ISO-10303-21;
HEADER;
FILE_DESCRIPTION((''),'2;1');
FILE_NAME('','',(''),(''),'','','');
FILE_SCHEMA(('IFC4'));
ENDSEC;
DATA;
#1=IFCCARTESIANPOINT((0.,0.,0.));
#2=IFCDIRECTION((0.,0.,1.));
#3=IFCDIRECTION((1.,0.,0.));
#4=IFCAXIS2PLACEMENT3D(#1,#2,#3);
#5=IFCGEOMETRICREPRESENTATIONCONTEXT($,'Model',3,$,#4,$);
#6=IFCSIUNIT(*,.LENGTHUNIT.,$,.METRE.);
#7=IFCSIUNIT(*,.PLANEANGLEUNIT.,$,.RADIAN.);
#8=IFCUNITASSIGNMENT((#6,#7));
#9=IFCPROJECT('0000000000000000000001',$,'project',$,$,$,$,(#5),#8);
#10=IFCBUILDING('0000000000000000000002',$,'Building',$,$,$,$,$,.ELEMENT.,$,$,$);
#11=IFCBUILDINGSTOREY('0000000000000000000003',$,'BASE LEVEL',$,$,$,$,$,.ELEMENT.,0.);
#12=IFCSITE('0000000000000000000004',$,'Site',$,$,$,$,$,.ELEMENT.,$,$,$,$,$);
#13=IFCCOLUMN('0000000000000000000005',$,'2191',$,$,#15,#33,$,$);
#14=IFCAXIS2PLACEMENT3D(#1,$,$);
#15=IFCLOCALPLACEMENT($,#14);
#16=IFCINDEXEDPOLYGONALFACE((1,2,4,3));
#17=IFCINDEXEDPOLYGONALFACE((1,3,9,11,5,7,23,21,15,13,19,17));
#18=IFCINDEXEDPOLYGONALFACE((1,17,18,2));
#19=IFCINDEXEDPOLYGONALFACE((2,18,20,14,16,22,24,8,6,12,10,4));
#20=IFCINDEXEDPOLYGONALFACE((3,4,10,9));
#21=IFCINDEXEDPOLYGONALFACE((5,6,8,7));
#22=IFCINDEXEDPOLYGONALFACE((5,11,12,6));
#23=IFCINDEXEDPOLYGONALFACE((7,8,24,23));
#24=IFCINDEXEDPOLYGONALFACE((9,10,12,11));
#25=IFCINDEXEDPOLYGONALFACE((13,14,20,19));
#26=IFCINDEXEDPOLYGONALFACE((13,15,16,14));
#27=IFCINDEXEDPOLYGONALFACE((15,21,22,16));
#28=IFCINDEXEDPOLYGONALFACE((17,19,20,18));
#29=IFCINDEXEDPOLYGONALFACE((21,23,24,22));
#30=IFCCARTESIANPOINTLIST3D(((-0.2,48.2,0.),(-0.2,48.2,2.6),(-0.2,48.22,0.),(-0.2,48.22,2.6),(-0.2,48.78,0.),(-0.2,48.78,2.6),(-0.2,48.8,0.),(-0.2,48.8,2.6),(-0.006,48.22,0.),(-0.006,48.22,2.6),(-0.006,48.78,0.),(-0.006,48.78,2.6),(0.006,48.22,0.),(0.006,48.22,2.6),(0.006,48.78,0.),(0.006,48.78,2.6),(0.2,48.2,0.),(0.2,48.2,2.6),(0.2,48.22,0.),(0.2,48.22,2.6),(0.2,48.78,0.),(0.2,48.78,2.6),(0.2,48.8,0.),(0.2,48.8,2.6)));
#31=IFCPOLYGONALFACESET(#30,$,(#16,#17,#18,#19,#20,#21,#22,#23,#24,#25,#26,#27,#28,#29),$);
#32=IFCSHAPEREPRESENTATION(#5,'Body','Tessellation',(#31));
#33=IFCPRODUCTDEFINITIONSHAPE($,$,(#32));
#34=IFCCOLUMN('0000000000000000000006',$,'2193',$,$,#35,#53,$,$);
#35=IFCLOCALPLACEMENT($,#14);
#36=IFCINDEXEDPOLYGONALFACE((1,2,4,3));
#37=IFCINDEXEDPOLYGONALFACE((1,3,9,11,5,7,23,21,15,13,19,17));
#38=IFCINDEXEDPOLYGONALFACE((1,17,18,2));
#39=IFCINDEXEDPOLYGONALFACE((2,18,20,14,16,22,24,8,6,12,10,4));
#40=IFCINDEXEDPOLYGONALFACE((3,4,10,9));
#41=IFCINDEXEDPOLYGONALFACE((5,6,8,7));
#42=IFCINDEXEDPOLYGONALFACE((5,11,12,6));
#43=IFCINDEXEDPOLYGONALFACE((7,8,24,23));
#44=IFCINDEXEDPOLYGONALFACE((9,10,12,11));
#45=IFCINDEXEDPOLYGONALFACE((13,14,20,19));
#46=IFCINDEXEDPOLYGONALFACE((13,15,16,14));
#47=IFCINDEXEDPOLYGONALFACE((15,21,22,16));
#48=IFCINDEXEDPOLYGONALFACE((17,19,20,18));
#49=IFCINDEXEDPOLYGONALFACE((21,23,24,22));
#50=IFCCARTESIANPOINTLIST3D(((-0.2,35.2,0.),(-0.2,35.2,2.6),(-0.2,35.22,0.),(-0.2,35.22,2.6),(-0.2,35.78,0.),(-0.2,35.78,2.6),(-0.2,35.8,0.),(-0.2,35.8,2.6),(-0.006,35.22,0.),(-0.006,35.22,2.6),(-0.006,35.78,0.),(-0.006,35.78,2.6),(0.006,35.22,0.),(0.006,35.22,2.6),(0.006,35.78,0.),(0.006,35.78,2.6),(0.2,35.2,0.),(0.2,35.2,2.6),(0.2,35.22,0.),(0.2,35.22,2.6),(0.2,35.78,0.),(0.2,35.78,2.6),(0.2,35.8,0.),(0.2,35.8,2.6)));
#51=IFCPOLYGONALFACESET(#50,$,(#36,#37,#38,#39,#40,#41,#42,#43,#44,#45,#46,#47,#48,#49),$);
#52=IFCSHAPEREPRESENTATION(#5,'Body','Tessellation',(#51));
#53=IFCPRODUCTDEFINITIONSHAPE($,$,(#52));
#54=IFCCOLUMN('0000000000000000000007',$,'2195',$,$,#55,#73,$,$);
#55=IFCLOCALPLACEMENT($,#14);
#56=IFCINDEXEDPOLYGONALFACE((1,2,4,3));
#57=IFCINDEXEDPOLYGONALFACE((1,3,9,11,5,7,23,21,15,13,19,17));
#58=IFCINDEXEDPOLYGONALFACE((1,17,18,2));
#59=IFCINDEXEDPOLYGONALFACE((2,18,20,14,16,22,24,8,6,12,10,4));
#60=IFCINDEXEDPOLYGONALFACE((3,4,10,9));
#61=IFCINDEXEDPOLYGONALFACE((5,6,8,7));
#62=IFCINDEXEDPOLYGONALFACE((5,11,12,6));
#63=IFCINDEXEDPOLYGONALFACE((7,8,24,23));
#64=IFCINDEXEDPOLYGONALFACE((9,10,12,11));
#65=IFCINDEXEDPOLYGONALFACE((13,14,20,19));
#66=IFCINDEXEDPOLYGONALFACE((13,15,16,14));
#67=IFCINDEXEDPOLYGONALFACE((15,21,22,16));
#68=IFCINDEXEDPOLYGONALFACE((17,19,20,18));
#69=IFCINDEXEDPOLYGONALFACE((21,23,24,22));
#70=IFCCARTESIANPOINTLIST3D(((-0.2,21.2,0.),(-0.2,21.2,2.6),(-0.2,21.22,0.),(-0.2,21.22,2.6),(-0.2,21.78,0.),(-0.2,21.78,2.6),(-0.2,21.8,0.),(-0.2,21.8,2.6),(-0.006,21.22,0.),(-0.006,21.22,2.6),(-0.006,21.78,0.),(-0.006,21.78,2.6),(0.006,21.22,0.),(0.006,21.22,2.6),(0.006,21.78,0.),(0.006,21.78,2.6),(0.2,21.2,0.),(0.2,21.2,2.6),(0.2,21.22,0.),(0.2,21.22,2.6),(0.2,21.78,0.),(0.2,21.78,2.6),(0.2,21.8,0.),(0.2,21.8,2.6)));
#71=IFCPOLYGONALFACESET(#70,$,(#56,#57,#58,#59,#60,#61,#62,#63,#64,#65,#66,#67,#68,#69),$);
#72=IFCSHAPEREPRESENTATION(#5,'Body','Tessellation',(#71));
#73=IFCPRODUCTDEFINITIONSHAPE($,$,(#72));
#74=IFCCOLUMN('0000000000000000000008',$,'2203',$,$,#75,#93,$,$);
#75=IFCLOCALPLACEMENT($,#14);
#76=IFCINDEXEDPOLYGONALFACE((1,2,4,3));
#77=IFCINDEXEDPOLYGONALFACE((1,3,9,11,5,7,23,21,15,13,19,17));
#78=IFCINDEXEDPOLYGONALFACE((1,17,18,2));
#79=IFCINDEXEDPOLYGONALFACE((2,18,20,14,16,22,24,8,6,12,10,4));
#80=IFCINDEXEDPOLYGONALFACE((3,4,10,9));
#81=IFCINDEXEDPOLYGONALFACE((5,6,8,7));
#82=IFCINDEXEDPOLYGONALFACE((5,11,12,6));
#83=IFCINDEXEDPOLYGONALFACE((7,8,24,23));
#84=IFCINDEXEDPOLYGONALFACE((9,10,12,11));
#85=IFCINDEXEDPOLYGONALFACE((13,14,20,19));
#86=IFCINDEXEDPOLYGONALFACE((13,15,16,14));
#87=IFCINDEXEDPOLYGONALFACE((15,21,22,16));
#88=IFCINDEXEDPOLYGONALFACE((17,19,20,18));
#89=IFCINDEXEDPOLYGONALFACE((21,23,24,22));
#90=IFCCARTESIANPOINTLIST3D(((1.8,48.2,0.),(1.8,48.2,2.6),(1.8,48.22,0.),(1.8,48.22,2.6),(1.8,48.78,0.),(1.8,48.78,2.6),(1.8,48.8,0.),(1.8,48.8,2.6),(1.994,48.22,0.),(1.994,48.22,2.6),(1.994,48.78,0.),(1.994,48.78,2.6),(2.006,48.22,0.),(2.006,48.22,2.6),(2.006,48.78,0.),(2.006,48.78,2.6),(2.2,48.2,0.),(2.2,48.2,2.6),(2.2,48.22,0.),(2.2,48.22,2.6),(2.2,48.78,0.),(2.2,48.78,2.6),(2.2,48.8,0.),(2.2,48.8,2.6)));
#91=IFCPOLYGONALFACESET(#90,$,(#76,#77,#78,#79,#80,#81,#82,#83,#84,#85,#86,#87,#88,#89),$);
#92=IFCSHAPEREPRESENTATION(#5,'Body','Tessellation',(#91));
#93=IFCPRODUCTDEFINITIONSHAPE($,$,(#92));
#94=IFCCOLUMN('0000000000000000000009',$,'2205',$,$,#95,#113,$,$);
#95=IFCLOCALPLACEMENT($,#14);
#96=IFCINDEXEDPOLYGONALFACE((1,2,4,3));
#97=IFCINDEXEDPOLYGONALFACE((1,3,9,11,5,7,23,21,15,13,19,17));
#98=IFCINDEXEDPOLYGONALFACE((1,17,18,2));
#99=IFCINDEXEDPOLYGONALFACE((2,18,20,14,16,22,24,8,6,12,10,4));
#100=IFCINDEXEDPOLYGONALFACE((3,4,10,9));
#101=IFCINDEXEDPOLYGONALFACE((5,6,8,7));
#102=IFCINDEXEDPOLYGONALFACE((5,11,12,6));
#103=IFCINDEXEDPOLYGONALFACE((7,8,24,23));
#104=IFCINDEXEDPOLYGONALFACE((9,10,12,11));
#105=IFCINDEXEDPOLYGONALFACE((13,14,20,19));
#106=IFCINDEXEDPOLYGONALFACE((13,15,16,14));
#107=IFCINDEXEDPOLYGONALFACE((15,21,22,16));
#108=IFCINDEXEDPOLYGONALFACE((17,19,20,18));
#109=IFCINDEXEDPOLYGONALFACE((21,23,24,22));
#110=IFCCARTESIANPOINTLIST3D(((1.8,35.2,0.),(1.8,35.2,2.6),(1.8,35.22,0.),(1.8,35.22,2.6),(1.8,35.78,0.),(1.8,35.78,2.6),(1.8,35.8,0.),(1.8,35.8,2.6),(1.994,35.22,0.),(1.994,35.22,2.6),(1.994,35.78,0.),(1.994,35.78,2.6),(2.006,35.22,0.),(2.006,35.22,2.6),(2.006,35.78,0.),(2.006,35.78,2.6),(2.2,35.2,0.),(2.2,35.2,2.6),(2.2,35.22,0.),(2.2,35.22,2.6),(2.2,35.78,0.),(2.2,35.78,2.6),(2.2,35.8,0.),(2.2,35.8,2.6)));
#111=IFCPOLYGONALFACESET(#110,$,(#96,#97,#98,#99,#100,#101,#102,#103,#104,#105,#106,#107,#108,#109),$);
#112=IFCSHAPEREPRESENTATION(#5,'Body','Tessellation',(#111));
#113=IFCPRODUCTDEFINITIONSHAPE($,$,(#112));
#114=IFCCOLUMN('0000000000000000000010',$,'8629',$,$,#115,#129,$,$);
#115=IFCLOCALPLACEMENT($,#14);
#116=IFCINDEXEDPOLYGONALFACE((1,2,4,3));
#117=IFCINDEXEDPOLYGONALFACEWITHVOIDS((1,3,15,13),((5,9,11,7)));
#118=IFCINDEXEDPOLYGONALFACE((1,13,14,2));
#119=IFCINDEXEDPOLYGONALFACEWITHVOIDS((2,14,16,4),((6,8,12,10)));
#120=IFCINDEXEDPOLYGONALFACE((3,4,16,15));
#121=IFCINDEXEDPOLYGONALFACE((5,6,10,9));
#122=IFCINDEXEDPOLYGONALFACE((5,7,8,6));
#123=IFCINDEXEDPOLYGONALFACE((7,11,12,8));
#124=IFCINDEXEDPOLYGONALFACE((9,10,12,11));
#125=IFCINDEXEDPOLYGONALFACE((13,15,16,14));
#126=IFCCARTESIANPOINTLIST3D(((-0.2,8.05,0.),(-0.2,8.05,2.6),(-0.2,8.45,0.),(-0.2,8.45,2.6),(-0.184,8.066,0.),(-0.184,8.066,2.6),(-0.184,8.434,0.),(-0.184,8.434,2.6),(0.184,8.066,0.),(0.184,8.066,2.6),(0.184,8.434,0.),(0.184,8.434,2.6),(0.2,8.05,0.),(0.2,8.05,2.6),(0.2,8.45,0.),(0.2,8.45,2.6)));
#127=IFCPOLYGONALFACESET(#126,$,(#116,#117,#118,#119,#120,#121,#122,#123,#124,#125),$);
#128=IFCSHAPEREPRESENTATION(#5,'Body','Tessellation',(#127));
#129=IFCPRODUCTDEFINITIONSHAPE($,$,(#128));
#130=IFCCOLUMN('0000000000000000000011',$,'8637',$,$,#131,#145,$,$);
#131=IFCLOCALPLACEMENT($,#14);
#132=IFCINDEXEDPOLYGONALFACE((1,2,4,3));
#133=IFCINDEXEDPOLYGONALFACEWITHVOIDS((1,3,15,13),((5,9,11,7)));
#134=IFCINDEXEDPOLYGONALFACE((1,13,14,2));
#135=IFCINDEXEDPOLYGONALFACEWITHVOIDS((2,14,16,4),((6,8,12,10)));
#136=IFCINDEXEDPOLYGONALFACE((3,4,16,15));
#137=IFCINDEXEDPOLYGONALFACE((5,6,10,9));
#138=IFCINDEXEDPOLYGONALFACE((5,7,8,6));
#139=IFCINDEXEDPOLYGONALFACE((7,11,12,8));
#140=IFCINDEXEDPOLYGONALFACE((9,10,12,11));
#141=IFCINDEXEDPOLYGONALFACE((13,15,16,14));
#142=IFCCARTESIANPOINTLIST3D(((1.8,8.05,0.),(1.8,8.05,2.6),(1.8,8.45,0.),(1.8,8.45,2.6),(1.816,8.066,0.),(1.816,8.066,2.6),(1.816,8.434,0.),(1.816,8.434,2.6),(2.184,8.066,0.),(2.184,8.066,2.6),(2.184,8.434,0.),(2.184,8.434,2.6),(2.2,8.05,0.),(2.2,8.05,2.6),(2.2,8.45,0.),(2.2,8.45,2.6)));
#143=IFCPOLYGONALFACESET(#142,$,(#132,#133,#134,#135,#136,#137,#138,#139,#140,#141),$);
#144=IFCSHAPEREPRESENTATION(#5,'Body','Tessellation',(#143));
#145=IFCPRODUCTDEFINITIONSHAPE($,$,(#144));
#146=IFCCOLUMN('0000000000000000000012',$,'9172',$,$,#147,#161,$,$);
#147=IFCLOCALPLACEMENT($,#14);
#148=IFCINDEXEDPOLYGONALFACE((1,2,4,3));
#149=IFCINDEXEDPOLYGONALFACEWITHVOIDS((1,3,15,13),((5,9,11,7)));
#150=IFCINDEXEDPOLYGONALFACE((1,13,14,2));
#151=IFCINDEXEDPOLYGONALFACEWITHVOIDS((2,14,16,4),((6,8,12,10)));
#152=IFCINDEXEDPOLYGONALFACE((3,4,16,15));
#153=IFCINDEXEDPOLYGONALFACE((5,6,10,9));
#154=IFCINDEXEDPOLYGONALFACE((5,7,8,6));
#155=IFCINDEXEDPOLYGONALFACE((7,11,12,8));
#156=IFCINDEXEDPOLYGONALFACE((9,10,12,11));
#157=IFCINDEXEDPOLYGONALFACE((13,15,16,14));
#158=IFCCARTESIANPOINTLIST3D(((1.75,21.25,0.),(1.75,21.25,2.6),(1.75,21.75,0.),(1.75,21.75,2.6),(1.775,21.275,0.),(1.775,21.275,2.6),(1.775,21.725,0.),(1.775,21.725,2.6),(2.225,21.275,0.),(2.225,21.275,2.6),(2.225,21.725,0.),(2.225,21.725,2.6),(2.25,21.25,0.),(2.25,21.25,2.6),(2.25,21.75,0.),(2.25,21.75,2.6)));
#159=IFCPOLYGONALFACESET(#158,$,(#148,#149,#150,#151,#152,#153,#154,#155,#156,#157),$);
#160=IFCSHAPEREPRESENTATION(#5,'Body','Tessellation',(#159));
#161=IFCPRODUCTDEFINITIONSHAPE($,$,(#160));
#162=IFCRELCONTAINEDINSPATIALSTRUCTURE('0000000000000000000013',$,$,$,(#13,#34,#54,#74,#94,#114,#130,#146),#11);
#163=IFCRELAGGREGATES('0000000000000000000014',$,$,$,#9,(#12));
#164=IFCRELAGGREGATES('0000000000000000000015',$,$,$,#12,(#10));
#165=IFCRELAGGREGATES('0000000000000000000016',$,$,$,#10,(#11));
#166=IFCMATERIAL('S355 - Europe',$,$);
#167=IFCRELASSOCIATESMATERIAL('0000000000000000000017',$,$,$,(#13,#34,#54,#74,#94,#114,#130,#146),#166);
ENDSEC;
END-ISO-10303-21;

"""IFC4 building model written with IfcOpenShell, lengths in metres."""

from ifc_helpers import new_model, si_unit, frame, origin_with_axes, origin_2d_with_axis, place, context, project, spatial, hollow_rectangle, i_section, extrude, material, material_profile, profile_set, profile_usage, element, save


model = new_model("IFC4")

# Units and contexts
model_context = context("Model", 3, world=origin_with_axes())
ifc_project = project(units=[si_unit("LENGTHUNIT", "METRE"), si_unit("PLANEANGLEUNIT", "RADIAN")], contexts=[model_context])

# Site, building, storey
site = spatial("IfcSite", under=ifc_project, Name="Site", CompositionType="ELEMENT")
building = spatial("IfcBuilding", under=site, Name="Building", CompositionType="ELEMENT")
storey = spatial("IfcBuildingStorey", under=building, Name="BASE LEVEL", CompositionType="ELEMENT", Elevation=0.0)

# Columns
ifc_material = material(Name="S355 - Europe")
ifc_material_profile_1 = material_profile(ifc_material, i_section(OverallWidth=0.4, OverallDepth=0.6, WebThickness=0.012, FlangeThickness=0.02, at=origin_2d_with_axis()))
ifc_profile_set_1 = profile_set([ifc_material_profile_1])
ifc_profile_usage_1 = profile_usage(ifc_profile_set_1, cardinal=10)
column_1_placement = place(None, frame((0.0, 48.5, 0.0), z_axis=(0.0, 0.0, 1.0), x_axis=(1.0, 0.0, 0.0)))
element("IfcColumn", 1, at=column_1_placement, inside=storey, material=ifc_profile_usage_1, Name="2191", context=model_context, shape_type="SweptSolid", body=[
    extrude(i_section(OverallWidth=0.4, OverallDepth=0.6, WebThickness=0.012, FlangeThickness=0.02, at=origin_2d_with_axis()), origin_with_axes(), (0.0, 0.0, 1.0), 2.6),
])
ifc_material_profile_2 = material_profile(ifc_material, i_section(OverallWidth=0.4, OverallDepth=0.6, WebThickness=0.012, FlangeThickness=0.02, at=origin_2d_with_axis()))
ifc_profile_set_2 = profile_set([ifc_material_profile_2])
ifc_profile_usage_2 = profile_usage(ifc_profile_set_2, cardinal=10)
column_2_placement = place(None, frame((0.0, 35.5, 0.0), z_axis=(0.0, 0.0, 1.0), x_axis=(1.0, 0.0, 0.0)))
element("IfcColumn", 2, at=column_2_placement, inside=storey, material=ifc_profile_usage_2, Name="2193", context=model_context, shape_type="SweptSolid", body=[
    extrude(i_section(OverallWidth=0.4, OverallDepth=0.6, WebThickness=0.012, FlangeThickness=0.02, at=origin_2d_with_axis()), origin_with_axes(), (0.0, 0.0, 1.0), 2.6),
])
ifc_material_profile_3 = material_profile(ifc_material, i_section(OverallWidth=0.4, OverallDepth=0.6, WebThickness=0.012, FlangeThickness=0.02, at=origin_2d_with_axis()))
ifc_profile_set_3 = profile_set([ifc_material_profile_3])
ifc_profile_usage_3 = profile_usage(ifc_profile_set_3, cardinal=10)
column_3_placement = place(None, frame((0.0, 21.5, 0.0), z_axis=(0.0, 0.0, 1.0), x_axis=(1.0, 0.0, 0.0)))
element("IfcColumn", 3, at=column_3_placement, inside=storey, material=ifc_profile_usage_3, Name="2195", context=model_context, shape_type="SweptSolid", body=[
    extrude(i_section(OverallWidth=0.4, OverallDepth=0.6, WebThickness=0.012, FlangeThickness=0.02, at=origin_2d_with_axis()), origin_with_axes(), (0.0, 0.0, 1.0), 2.6),
])
ifc_material_profile_4 = material_profile(ifc_material, i_section(OverallWidth=0.4, OverallDepth=0.6, WebThickness=0.012, FlangeThickness=0.02, at=origin_2d_with_axis()))
ifc_profile_set_4 = profile_set([ifc_material_profile_4])
ifc_profile_usage_4 = profile_usage(ifc_profile_set_4, cardinal=10)
column_4_placement = place(None, frame((2.0, 48.5, 0.0), z_axis=(0.0, 0.0, 1.0), x_axis=(1.0, 0.0, 0.0)))
element("IfcColumn", 4, at=column_4_placement, inside=storey, material=ifc_profile_usage_4, Name="2203", context=model_context, shape_type="SweptSolid", body=[
    extrude(i_section(OverallWidth=0.4, OverallDepth=0.6, WebThickness=0.012, FlangeThickness=0.02, at=origin_2d_with_axis()), origin_with_axes(), (0.0, 0.0, 1.0), 2.6),
])
ifc_material_profile_5 = material_profile(ifc_material, i_section(OverallWidth=0.4, OverallDepth=0.6, WebThickness=0.012, FlangeThickness=0.02, at=origin_2d_with_axis()))
ifc_profile_set_5 = profile_set([ifc_material_profile_5])
ifc_profile_usage_5 = profile_usage(ifc_profile_set_5, cardinal=10)
column_5_placement = place(None, frame((2.0, 35.5, 0.0), z_axis=(0.0, 0.0, 1.0), x_axis=(1.0, 0.0, 0.0)))
element("IfcColumn", 5, at=column_5_placement, inside=storey, material=ifc_profile_usage_5, Name="2205", context=model_context, shape_type="SweptSolid", body=[
    extrude(i_section(OverallWidth=0.4, OverallDepth=0.6, WebThickness=0.012, FlangeThickness=0.02, at=origin_2d_with_axis()), origin_with_axes(), (0.0, 0.0, 1.0), 2.6),
])
ifc_material_profile_6 = material_profile(ifc_material, hollow_rectangle(XDim=0.4, YDim=0.4, WallThickness=0.016, at=origin_2d_with_axis()))
ifc_profile_set_6 = profile_set([ifc_material_profile_6])
ifc_profile_usage_6 = profile_usage(ifc_profile_set_6, cardinal=10)
column_6_placement = place(None, frame((0.0, 8.25, 0.0), z_axis=(0.0, 0.0, 1.0), x_axis=(0.0, -1.0, 0.0)))
element("IfcColumn", 6, at=column_6_placement, inside=storey, material=ifc_profile_usage_6, Name="8629", context=model_context, shape_type="SweptSolid", body=[
    extrude(hollow_rectangle(XDim=0.4, YDim=0.4, WallThickness=0.016, at=origin_2d_with_axis()), origin_with_axes(), (0.0, 0.0, 1.0), 2.6),
])
ifc_material_profile_7 = material_profile(ifc_material, hollow_rectangle(XDim=0.4, YDim=0.4, WallThickness=0.016, at=origin_2d_with_axis()))
ifc_profile_set_7 = profile_set([ifc_material_profile_7])
ifc_profile_usage_7 = profile_usage(ifc_profile_set_7, cardinal=10)
column_7_placement = place(None, frame((2.0, 8.25, 0.0), z_axis=(0.0, 0.0, 1.0), x_axis=(0.0, -1.0, 0.0)))
element("IfcColumn", 7, at=column_7_placement, inside=storey, material=ifc_profile_usage_7, Name="8637", context=model_context, shape_type="SweptSolid", body=[
    extrude(hollow_rectangle(XDim=0.4, YDim=0.4, WallThickness=0.016, at=origin_2d_with_axis()), origin_with_axes(), (0.0, 0.0, 1.0), 2.6),
])
ifc_material_profile_8 = material_profile(ifc_material, hollow_rectangle(XDim=0.5, YDim=0.5, WallThickness=0.025, at=origin_2d_with_axis()))
ifc_profile_set_8 = profile_set([ifc_material_profile_8])
ifc_profile_usage_8 = profile_usage(ifc_profile_set_8, cardinal=10)
column_8_placement = place(None, frame((2.0, 21.5, 0.0), z_axis=(0.0, 0.0, 1.0), x_axis=(1.0, 0.0, 0.0)))
element("IfcColumn", 8, at=column_8_placement, inside=storey, material=ifc_profile_usage_8, Name="9172", context=model_context, shape_type="SweptSolid", body=[
    extrude(hollow_rectangle(XDim=0.5, YDim=0.5, WallThickness=0.025, at=origin_2d_with_axis()), origin_with_axes(), (0.0, 0.0, 1.0), 2.6),
])

save(model, "model.ifc")
